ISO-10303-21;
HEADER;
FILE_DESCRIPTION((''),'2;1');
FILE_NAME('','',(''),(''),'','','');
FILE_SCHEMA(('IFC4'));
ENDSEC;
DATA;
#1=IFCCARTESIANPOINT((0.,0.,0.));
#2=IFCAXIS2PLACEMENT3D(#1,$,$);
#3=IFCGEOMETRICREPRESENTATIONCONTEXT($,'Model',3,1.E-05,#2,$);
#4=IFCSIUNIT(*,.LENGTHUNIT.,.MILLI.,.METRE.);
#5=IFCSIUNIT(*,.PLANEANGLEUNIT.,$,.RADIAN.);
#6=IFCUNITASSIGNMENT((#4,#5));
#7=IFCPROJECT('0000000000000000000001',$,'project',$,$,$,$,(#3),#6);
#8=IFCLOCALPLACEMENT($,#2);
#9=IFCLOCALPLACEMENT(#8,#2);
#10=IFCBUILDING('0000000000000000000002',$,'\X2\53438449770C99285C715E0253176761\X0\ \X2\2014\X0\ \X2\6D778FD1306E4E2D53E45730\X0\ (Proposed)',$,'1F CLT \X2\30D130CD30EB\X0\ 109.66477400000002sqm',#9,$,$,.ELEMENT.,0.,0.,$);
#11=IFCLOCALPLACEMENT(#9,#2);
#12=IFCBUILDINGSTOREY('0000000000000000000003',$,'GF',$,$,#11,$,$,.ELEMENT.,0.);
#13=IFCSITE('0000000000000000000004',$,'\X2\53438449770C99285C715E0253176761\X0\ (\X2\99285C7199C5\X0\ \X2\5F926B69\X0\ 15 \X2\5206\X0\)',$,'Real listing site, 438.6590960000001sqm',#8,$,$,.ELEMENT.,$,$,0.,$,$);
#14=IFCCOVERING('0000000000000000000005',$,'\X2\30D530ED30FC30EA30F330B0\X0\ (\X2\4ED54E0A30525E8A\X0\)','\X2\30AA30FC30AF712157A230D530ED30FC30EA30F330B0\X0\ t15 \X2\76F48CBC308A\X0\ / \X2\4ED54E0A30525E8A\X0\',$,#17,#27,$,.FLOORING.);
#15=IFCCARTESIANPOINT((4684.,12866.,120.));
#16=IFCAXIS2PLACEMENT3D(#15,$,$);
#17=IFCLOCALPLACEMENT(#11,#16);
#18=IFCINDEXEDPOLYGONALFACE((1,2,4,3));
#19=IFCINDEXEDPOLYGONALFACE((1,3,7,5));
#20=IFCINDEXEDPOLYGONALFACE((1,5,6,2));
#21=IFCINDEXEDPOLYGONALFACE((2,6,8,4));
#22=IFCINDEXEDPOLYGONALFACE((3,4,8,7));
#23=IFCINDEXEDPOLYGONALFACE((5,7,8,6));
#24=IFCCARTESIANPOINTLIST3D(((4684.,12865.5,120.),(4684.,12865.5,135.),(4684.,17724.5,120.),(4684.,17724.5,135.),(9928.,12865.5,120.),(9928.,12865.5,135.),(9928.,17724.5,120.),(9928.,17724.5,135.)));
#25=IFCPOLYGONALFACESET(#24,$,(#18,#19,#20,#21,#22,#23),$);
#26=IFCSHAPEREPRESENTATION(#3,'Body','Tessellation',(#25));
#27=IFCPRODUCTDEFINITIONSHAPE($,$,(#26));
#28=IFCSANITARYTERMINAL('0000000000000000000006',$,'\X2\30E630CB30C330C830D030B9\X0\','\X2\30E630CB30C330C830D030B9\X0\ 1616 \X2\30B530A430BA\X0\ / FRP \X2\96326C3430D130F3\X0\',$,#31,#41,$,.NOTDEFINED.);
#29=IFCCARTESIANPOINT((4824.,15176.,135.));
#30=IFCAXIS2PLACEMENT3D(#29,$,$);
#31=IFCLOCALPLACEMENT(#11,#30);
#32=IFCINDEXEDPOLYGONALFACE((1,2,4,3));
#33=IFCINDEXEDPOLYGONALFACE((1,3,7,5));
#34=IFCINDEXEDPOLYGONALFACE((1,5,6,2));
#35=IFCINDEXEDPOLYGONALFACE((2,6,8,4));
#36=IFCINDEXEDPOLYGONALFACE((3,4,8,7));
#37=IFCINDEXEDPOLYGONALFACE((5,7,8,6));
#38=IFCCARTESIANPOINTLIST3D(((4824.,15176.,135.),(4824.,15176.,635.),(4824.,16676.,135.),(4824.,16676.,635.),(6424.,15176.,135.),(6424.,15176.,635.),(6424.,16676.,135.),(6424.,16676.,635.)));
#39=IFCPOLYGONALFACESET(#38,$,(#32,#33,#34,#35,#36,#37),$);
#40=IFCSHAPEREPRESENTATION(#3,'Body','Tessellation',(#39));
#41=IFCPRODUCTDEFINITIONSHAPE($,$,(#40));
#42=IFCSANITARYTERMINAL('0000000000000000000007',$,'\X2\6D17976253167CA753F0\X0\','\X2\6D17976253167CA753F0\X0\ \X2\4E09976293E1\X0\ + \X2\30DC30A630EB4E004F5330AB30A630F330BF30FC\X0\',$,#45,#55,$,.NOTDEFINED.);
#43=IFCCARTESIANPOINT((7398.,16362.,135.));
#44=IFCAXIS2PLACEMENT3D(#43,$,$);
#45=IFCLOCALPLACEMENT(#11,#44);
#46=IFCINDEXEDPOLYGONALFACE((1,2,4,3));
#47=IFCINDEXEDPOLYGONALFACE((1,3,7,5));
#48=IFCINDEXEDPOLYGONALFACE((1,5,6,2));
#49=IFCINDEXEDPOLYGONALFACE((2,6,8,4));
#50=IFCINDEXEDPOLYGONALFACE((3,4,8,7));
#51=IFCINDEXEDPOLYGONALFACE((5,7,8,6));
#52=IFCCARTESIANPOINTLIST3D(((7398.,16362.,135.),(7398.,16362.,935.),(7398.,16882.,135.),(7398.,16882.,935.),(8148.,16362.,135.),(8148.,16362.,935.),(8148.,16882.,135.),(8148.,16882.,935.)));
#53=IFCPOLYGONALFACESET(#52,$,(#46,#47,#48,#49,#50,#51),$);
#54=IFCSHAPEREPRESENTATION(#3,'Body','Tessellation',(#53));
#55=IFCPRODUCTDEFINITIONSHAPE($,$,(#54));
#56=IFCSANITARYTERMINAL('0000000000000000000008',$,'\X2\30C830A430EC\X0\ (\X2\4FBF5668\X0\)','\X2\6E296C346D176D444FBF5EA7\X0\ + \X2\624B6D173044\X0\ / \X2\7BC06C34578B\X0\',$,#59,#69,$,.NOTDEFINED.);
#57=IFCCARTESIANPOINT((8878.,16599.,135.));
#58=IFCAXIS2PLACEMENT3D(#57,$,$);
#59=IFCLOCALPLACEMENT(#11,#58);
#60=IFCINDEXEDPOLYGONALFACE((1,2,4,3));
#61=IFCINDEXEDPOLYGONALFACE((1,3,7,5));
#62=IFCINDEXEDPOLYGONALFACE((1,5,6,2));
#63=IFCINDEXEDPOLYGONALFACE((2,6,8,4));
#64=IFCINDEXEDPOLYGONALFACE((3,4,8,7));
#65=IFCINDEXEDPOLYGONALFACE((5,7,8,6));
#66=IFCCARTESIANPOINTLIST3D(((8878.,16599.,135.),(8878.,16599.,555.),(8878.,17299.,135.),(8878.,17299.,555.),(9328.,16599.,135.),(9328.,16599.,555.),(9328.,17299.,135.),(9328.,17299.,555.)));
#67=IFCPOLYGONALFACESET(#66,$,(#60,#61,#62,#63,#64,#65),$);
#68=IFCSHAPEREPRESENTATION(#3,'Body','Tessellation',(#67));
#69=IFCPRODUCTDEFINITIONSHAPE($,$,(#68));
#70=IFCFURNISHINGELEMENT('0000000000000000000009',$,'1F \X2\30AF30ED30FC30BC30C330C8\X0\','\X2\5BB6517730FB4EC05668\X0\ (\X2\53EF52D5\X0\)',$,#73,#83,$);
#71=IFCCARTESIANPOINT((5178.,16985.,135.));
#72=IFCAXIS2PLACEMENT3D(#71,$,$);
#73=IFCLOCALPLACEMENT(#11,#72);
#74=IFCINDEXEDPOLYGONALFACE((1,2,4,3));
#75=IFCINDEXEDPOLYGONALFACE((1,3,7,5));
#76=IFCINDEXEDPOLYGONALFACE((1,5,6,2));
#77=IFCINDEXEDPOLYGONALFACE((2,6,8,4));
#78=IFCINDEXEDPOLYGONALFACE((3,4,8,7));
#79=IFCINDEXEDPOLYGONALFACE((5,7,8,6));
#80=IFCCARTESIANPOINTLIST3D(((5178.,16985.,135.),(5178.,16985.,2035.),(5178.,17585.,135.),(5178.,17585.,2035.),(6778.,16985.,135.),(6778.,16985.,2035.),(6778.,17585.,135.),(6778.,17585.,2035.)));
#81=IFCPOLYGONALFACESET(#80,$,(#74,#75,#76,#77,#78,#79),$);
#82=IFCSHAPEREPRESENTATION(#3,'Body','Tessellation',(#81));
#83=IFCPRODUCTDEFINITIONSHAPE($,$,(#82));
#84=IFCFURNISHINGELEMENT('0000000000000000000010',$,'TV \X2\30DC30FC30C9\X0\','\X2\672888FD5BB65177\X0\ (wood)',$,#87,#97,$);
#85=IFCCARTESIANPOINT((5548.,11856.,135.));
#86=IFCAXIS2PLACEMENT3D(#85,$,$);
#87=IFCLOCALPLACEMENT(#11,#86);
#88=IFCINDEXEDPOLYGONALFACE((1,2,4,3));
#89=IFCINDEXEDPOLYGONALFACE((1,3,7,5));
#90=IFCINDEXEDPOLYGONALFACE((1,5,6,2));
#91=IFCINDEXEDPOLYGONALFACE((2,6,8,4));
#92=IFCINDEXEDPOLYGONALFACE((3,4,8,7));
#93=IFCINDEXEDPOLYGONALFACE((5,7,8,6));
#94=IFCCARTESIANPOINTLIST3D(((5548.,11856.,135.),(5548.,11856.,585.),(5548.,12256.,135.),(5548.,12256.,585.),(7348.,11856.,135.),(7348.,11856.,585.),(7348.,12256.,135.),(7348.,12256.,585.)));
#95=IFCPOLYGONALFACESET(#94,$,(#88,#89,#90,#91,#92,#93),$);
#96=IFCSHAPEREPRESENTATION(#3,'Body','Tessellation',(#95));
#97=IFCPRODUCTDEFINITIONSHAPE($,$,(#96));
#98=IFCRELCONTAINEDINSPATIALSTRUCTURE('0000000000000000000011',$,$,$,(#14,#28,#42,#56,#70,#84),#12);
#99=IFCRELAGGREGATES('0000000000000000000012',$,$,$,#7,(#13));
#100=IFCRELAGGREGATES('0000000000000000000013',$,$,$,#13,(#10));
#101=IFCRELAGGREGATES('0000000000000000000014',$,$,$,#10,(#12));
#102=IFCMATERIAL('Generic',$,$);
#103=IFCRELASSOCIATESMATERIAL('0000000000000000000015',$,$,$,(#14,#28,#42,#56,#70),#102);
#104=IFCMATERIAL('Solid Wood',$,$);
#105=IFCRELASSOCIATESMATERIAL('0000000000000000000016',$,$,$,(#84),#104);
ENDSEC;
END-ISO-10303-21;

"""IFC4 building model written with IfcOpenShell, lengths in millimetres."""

from ifc_helpers import new_model, si_unit, frame, frame_2d, origin, place, context, project, spatial, rectangle, extrude, material, element, save


model = new_model("IFC4")

# Units and contexts
model_context = context("Model", 3, precision=1e-05, world=origin())
ifc_project = project(units=[si_unit("LENGTHUNIT", "METRE", prefix="MILLI"), si_unit("PLANEANGLEUNIT", "RADIAN")], contexts=[model_context])

# Site, building, storey
site_placement = place(None, origin())
site = spatial("IfcSite", under=ifc_project, at=site_placement, Name="千葉県館山市北条 (館山駅 徒歩 15 分)", ObjectType="Real listing site, 438.6590960000001sqm", CompositionType="ELEMENT", RefElevation=0.0)
building_placement = place(site_placement, origin())
building = spatial("IfcBuilding", under=site, at=building_placement, Name="千葉県館山市北条 — 海近の中古地 (Proposed)", ObjectType="1F CLT パネル 109.66477400000002sqm", CompositionType="ELEMENT", ElevationOfRefHeight=0.0, ElevationOfTerrain=0.0)
storey_placement = place(building_placement, origin())
storey = spatial("IfcBuildingStorey", under=building, at=storey_placement, Name="GF", CompositionType="ELEMENT", Elevation=0.0)

# Shared definitions
ifc_material_1 = material(Name="Solid Wood")

# Covering
ifc_material_2 = material(Name="Generic")
covering_placement = place(storey_placement, frame((4684.0, 12866.0, 120.0)))
element("IfcCovering", 1, at=covering_placement, inside=storey, material=ifc_material_2, Name="フローリング (仕上げ床)", Description="オーク無垢フローリング t15 直貼り / 仕上げ床", PredefinedType="FLOORING", context=model_context, shape_type="SweptSolid", body=[
    extrude(rectangle(XDim=5244.0, YDim=4859.0, at=frame_2d((2622.0, 2429.0))), frame((4684.0, 12866.0, 120.0)), (0.0, 0.0, 1.0), 15.0),
])

# Sanitary terminals
sanitary_terminal_1_placement = place(storey_placement, frame((4824.0, 15176.0, 135.0)))
element("IfcSanitaryTerminal", 2, at=sanitary_terminal_1_placement, inside=storey, material=ifc_material_2, Name="ユニットバス", Description="ユニットバス 1616 サイズ / FRP 防水パン", PredefinedType="NOTDEFINED", context=model_context, shape_type="SweptSolid", body=[
    extrude(rectangle(XDim=1600.0, YDim=1500.0, at=frame_2d((800.0, 750.0))), frame((4824.0, 15176.0, 135.0)), (0.0, 0.0, 1.0), 500.0),
])
sanitary_terminal_2_placement = place(storey_placement, frame((7398.0, 16362.0, 135.0)))
element("IfcSanitaryTerminal", 3, at=sanitary_terminal_2_placement, inside=storey, material=ifc_material_2, Name="洗面化粧台", Description="洗面化粧台 三面鏡 + ボウル一体カウンター", PredefinedType="NOTDEFINED", context=model_context, shape_type="SweptSolid", body=[
    extrude(rectangle(XDim=750.0, YDim=520.0, at=frame_2d((375.0, 260.0))), frame((7398.0, 16362.0, 135.0)), (0.0, 0.0, 1.0), 800.0),
])
sanitary_terminal_3_placement = place(storey_placement, frame((8878.0, 16599.0, 135.0)))
element("IfcSanitaryTerminal", 4, at=sanitary_terminal_3_placement, inside=storey, material=ifc_material_2, Name="トイレ (便器)", Description="温水洗浄便座 + 手洗い / 節水型", PredefinedType="NOTDEFINED", context=model_context, shape_type="SweptSolid", body=[
    extrude(rectangle(XDim=450.0, YDim=700.0, at=frame_2d((225.0, 350.0))), frame((8878.0, 16599.0, 135.0)), (0.0, 0.0, 1.0), 420.0),
])

# Furnishing elements
furnishing_1_placement = place(storey_placement, frame((5178.0, 16985.0, 135.0)))
element("IfcFurnishingElement", 5, at=furnishing_1_placement, inside=storey, material=ifc_material_2, Name="1F クローゼット", Description="家具・什器 (可動)", context=model_context, shape_type="SweptSolid", body=[
    extrude(rectangle(XDim=1600.0, YDim=600.0, at=frame_2d((800.0, 300.0))), frame((5178.0, 16985.0, 135.0)), (0.0, 0.0, 1.0), 1900.0),
])
furnishing_2_placement = place(storey_placement, frame((5548.0, 11856.0, 135.0)))
element("IfcFurnishingElement", 6, at=furnishing_2_placement, inside=storey, material=ifc_material_1, Name="TV ボード", Description="木製家具 (wood)", context=model_context, shape_type="SweptSolid", body=[
    extrude(rectangle(XDim=1800.0, YDim=400.0, at=frame_2d((900.0, 200.0))), frame((5548.0, 11856.0, 135.0)), (0.0, 0.0, 1.0), 450.0),
])

save(model, "model.ifc")
